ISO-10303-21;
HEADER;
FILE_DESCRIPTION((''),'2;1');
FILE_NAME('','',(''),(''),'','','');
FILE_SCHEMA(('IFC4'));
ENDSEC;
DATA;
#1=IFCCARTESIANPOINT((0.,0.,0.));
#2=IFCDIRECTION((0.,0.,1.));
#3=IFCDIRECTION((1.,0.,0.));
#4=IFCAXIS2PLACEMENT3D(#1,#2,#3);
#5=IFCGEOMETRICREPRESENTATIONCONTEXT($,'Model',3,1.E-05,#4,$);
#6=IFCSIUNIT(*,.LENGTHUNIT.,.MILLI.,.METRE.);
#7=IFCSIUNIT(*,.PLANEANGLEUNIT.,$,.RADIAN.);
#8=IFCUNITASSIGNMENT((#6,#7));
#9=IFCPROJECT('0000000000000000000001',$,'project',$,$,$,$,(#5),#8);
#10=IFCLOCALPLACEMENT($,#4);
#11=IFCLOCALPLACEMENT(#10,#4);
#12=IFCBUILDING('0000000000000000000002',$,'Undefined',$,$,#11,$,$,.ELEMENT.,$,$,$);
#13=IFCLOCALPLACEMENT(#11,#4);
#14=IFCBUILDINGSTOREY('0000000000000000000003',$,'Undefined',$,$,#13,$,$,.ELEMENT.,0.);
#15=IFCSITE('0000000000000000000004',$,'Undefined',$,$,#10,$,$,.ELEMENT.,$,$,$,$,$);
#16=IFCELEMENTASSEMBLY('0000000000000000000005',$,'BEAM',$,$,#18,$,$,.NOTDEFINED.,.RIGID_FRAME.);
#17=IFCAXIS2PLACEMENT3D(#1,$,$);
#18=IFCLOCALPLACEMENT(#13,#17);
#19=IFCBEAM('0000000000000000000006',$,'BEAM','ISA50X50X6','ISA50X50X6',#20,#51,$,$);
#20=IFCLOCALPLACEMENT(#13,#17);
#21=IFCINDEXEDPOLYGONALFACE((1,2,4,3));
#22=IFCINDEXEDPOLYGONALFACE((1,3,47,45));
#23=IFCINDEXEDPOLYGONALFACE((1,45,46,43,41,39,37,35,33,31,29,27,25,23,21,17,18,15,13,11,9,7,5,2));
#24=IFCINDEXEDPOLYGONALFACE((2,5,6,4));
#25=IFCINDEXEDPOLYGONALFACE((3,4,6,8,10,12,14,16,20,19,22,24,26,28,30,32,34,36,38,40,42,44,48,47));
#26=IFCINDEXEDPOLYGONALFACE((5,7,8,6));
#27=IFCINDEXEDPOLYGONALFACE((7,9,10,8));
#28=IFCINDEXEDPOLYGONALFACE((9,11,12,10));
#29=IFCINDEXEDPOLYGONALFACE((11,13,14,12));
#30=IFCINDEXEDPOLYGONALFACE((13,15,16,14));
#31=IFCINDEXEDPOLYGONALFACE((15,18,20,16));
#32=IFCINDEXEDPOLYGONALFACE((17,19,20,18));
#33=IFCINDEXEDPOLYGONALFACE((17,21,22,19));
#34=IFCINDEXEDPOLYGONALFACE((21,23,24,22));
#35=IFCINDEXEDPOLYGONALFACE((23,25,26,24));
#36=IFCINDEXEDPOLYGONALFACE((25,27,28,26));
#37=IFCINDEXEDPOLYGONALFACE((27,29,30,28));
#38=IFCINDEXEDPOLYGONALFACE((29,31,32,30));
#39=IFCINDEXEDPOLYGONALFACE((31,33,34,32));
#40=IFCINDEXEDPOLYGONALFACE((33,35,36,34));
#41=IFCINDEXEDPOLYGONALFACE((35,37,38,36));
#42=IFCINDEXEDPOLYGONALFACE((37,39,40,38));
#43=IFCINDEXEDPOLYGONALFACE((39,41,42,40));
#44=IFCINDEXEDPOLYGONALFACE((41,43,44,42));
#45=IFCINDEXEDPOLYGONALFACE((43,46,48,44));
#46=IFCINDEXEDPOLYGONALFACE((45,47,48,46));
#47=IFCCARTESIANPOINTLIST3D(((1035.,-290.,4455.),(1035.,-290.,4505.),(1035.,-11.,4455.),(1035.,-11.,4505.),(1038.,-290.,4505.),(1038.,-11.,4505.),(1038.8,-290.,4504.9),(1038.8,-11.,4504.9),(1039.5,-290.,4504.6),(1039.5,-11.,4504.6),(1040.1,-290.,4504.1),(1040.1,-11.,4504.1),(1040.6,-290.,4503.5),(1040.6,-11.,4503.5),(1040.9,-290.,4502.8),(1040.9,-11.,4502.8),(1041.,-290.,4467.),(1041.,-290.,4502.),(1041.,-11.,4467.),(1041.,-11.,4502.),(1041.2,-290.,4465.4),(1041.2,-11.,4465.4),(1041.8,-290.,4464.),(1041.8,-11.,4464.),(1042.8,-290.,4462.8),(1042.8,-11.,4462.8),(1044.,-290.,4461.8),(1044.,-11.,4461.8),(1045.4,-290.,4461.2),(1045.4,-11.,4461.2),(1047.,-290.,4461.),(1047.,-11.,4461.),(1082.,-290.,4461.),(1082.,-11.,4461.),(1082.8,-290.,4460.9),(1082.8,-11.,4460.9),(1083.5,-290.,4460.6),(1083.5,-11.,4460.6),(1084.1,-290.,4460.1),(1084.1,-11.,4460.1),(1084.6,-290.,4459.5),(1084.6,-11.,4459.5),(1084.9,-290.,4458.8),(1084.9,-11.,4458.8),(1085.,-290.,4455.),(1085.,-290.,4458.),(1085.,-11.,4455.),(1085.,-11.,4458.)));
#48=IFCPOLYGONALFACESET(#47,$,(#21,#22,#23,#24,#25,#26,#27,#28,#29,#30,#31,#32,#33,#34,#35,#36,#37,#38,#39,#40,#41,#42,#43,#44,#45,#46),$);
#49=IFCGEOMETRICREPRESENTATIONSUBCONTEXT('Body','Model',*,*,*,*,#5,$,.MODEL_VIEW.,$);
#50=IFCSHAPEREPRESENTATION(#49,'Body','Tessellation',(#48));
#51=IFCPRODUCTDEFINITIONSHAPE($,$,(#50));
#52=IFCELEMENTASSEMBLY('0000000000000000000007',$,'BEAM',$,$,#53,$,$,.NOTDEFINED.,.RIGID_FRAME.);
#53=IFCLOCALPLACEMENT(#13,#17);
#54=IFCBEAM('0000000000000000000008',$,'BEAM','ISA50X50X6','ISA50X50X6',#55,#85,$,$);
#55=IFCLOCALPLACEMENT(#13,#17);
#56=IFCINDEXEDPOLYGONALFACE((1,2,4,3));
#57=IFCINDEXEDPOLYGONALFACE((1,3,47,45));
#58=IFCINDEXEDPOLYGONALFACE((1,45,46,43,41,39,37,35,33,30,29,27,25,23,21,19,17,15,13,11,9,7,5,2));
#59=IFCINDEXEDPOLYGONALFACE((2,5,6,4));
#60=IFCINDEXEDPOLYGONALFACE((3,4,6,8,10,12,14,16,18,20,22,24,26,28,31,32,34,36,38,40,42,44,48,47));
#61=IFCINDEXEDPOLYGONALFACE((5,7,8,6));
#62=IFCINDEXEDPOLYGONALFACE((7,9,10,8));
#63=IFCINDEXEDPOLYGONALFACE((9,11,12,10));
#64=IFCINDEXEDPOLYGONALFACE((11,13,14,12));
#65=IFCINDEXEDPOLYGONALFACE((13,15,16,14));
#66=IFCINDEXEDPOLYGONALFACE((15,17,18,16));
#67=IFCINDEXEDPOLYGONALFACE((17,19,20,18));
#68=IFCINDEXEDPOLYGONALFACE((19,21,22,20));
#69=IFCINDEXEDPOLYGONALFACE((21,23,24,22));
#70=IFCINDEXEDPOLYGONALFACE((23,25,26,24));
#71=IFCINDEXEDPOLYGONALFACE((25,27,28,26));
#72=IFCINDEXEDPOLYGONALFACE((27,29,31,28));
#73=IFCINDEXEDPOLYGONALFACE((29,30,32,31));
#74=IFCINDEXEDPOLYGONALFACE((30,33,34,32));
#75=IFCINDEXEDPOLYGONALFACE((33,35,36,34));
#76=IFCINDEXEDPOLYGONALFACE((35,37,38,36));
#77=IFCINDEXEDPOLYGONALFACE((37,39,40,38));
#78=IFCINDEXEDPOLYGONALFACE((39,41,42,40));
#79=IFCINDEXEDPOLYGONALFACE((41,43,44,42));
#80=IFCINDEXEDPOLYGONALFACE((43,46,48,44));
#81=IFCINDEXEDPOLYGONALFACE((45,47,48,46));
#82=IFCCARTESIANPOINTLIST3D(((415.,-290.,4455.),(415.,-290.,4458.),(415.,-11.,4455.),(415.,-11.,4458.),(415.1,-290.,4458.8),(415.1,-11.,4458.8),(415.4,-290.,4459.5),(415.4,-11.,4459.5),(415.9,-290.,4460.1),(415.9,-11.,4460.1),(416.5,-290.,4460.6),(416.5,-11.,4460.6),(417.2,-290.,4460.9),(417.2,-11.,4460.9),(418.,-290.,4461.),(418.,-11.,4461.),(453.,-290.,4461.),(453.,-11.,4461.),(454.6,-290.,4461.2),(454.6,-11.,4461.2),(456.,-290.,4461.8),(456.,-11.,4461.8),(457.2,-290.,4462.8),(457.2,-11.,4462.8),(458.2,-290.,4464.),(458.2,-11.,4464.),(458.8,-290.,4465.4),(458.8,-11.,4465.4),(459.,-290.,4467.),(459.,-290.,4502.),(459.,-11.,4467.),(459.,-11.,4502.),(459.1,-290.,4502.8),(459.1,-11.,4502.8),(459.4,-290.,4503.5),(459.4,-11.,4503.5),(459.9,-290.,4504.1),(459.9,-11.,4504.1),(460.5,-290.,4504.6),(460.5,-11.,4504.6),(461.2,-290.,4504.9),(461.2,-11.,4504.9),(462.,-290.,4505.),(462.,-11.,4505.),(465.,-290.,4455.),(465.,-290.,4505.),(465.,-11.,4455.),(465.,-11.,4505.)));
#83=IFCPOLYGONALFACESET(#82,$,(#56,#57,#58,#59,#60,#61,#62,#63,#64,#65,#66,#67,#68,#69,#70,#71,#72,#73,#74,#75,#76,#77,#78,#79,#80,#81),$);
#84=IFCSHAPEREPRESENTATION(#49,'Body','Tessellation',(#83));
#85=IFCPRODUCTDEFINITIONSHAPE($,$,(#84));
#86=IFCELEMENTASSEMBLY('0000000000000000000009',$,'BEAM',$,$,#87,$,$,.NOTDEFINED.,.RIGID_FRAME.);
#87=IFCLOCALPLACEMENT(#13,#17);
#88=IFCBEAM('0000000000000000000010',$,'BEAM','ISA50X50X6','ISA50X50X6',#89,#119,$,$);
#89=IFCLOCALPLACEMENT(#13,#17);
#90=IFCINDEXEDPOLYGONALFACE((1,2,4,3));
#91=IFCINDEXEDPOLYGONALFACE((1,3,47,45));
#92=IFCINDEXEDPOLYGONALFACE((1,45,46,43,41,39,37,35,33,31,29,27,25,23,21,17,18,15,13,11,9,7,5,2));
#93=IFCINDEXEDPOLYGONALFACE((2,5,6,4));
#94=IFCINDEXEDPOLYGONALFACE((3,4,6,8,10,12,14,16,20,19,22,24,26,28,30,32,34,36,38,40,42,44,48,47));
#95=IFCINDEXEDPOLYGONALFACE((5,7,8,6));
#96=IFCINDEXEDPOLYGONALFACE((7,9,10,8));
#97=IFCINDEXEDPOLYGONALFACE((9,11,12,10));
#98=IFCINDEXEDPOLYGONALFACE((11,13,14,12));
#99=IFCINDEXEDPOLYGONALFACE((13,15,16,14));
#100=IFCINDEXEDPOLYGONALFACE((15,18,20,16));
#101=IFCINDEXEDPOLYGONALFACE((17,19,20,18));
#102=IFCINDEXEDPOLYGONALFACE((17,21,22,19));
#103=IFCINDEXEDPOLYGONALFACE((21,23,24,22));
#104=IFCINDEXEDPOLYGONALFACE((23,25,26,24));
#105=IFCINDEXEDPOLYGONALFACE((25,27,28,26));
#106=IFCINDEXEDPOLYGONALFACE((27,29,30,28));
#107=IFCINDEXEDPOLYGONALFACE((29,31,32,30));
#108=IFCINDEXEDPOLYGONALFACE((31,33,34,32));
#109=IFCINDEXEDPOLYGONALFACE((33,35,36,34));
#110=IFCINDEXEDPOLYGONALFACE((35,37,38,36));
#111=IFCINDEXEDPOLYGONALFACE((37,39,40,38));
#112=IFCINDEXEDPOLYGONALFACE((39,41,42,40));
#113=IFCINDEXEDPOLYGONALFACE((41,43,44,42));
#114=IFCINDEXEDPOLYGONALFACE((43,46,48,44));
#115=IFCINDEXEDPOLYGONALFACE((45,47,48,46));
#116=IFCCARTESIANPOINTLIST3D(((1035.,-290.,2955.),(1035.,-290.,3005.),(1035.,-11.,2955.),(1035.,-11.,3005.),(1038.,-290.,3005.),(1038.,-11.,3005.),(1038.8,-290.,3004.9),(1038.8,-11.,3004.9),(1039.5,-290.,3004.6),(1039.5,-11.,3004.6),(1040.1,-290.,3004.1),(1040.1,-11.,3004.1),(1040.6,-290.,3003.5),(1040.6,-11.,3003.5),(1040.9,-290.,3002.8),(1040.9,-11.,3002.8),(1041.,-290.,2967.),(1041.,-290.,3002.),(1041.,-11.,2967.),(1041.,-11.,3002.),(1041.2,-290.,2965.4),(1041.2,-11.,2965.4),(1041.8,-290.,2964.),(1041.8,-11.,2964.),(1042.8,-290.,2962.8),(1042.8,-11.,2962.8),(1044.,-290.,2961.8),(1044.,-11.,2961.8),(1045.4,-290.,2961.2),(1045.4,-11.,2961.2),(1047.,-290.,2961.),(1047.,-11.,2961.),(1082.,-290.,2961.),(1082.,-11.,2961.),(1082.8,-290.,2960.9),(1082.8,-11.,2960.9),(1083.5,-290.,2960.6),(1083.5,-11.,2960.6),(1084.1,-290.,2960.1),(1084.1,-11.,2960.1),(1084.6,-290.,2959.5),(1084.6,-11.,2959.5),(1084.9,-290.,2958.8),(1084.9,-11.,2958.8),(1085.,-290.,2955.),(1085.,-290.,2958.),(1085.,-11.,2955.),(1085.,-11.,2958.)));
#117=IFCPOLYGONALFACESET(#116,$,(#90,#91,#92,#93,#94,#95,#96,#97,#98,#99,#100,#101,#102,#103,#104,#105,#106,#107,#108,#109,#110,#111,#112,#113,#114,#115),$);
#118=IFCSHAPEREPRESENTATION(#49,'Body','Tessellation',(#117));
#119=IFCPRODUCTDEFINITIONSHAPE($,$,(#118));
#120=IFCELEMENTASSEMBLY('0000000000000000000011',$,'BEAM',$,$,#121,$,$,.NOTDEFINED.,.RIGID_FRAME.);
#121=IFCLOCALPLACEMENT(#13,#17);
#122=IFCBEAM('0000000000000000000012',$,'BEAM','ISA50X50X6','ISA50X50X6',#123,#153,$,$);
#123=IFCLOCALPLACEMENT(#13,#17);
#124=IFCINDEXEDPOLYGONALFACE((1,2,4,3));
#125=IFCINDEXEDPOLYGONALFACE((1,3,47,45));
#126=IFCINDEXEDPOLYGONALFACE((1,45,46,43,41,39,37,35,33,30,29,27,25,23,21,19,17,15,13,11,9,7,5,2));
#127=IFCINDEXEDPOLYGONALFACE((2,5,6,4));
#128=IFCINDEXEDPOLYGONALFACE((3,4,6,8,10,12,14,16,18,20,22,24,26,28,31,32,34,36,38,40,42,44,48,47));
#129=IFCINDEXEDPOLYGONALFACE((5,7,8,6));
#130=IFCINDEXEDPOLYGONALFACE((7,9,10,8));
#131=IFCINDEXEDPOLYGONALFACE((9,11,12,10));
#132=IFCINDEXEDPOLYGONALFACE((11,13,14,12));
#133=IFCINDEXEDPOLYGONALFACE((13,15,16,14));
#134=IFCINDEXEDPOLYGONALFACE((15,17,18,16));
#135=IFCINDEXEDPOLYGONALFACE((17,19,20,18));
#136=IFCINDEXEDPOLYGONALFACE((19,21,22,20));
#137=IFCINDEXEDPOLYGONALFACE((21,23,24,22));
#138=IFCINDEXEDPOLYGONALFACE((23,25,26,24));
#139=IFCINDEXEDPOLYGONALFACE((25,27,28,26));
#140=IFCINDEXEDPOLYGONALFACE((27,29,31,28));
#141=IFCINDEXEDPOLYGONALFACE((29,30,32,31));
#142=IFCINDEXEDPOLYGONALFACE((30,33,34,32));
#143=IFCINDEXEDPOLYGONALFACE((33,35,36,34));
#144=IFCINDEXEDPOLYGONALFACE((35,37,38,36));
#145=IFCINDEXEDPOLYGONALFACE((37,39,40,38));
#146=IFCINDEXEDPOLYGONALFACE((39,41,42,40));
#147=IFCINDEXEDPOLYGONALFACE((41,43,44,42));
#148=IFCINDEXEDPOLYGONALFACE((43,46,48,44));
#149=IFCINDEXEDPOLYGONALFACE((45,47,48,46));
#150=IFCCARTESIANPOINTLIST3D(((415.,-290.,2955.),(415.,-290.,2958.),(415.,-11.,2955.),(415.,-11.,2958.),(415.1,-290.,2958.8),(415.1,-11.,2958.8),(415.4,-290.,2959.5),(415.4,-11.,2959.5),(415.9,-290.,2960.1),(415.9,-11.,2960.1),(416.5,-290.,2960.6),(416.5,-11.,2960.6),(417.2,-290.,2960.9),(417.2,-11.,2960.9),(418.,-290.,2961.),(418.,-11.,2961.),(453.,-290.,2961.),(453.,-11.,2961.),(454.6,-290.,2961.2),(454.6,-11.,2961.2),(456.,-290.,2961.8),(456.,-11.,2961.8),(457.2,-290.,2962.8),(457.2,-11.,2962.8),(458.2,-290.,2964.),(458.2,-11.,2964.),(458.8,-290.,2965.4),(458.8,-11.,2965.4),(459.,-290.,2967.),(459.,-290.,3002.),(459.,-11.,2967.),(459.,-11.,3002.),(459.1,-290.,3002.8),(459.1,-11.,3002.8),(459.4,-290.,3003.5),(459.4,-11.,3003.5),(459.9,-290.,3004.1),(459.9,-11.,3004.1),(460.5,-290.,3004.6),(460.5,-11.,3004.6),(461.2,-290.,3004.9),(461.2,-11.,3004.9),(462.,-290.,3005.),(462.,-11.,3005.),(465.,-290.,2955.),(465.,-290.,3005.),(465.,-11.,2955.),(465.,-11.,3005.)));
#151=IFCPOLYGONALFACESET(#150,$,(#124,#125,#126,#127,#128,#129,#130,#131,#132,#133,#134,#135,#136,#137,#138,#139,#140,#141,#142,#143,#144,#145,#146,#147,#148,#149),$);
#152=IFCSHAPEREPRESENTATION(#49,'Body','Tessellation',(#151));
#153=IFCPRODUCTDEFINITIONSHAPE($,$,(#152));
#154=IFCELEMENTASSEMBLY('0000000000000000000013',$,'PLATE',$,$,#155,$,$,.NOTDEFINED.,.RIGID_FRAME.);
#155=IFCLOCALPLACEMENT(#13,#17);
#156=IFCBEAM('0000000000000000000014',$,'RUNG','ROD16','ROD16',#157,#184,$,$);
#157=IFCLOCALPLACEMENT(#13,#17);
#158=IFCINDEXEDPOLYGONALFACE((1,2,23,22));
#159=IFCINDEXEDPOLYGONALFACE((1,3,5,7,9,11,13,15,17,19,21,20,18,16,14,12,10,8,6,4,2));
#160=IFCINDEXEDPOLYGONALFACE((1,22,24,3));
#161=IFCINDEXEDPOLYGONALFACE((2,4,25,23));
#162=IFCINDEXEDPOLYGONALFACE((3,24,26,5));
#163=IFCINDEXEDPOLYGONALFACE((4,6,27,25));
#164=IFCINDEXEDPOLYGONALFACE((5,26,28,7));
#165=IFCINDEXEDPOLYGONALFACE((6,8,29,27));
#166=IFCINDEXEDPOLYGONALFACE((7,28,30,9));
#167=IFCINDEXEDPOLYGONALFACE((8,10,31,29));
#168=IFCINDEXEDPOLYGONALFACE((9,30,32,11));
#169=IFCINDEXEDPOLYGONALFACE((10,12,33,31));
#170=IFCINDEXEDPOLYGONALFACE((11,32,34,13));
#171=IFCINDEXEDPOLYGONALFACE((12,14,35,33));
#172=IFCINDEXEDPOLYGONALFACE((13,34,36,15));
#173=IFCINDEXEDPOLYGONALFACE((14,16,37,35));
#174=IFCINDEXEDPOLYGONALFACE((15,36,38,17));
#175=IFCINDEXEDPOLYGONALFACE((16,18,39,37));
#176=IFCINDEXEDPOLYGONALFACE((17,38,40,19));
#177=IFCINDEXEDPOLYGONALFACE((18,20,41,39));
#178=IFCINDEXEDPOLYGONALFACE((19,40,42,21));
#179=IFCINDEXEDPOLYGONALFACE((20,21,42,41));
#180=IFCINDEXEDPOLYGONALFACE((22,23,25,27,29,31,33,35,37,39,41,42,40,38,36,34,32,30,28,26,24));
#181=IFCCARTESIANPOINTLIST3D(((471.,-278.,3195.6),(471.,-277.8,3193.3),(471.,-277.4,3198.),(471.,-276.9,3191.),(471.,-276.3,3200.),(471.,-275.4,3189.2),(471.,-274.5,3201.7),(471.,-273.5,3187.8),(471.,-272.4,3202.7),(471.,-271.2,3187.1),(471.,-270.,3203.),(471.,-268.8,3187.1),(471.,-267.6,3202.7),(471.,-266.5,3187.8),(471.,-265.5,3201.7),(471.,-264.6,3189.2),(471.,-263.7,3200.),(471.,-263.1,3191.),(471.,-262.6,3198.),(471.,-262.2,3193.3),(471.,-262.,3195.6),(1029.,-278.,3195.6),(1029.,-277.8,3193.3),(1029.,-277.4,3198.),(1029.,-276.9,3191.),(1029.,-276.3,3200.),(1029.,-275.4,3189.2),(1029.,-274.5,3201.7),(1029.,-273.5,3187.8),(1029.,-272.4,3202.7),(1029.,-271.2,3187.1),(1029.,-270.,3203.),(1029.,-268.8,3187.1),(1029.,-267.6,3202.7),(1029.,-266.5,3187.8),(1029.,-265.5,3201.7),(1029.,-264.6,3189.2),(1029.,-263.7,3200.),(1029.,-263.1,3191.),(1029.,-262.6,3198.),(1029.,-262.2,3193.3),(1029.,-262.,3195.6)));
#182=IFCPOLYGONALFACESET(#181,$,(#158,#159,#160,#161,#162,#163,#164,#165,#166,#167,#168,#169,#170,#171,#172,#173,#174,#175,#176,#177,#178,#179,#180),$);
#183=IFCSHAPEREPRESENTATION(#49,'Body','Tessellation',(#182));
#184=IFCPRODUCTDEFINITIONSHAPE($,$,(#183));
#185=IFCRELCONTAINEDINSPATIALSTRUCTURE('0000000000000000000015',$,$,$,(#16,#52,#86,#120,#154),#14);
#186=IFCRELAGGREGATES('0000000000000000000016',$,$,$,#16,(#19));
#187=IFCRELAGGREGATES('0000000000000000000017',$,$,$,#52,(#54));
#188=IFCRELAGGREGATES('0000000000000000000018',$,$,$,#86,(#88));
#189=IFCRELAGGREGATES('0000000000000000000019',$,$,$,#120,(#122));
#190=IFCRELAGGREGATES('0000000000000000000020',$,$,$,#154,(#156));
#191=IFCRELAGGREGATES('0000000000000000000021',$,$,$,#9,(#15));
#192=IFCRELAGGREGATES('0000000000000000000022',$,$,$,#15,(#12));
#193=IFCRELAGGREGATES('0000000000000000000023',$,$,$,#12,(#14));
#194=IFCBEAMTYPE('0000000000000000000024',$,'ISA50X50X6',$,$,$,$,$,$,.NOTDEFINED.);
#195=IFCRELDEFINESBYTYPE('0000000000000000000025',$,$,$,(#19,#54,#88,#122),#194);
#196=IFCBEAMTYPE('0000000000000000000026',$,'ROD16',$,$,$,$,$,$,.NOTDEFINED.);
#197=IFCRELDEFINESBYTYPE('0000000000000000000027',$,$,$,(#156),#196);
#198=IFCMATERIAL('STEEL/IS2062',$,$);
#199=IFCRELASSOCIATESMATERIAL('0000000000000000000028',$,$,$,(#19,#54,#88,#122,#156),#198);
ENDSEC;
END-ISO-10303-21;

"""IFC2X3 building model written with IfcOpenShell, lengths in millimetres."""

from ifc_helpers import new_model, si_unit, frame, origin_with_axes, origin_2d_with_axis, place, context, subcontext, project, spatial, circle, l_section, extrude, material, type_object, element, aggregate, save


model = new_model("IFC2X3")

# Units and contexts
model_context = context("Model", 3, precision=1e-05, world=origin_with_axes())
body_context = subcontext(model_context, "Body", "Model", "MODEL_VIEW")
ifc_project = project(units=[si_unit("LENGTHUNIT", "METRE", prefix="MILLI"), si_unit("PLANEANGLEUNIT", "RADIAN")], contexts=[model_context])

# Site, building, storey
site_placement = place(None, origin_with_axes())
site = spatial("IfcSite", under=ifc_project, at=site_placement, Name="Undefined", CompositionType="ELEMENT")
building_placement = place(site_placement, origin_with_axes())
building = spatial("IfcBuilding", under=site, at=building_placement, Name="Undefined", CompositionType="ELEMENT")
storey_placement = place(building_placement, origin_with_axes())
storey = spatial("IfcBuildingStorey", under=building, at=storey_placement, Name="Undefined", CompositionType="ELEMENT", Elevation=0.0)

# Element assemblies, beams
assembly_1_placement = place(storey_placement, origin_with_axes())
assembly_1 = element("IfcElementAssembly", 1, at=assembly_1_placement, inside=storey, Name="BEAM", AssemblyPlace="NOTDEFINED", PredefinedType="RIGID_FRAME")
ifc_material = material(Name="STEEL/IS2062")
beam_type_1 = type_object("IfcBeamType", Name="ISA50X50X6", PredefinedType="NOTDEFINED")
beam_1_placement = place(assembly_1_placement, frame((1060.0, -290.0, 4480.0), z_axis=(0.0, 0.0, 1.0), x_axis=(0.0, 1.0, 0.0)))
beam_1 = element("IfcBeam", 2, at=beam_1_placement, type_object=beam_type_1, material=ifc_material, Name="BEAM", Description="ISA50X50X6", ObjectType="ISA50X50X6", context=body_context, shape_type="SweptSolid", body=[
    extrude(l_section(Depth=50.0, Width=50.0, Thickness=6.0, FilletRadius=6.0, EdgeRadius=3.0, at=origin_2d_with_axis()), frame((279.0, 0.0, 0.0), z_axis=(-1.0, 0.0, 0.0), x_axis=(0.0, -1.0, 0.0)), (0.0, 0.0, 1.0), 279.0),
])
aggregate(assembly_1, [beam_1])
assembly_2_placement = place(storey_placement, origin_with_axes())
assembly_2 = element("IfcElementAssembly", 3, at=assembly_2_placement, inside=storey, Name="BEAM", AssemblyPlace="NOTDEFINED", PredefinedType="RIGID_FRAME")
beam_2_placement = place(assembly_2_placement, frame((440.0, -11.0, 4480.0), z_axis=(0.0, 0.0, 1.0), x_axis=(0.0, -1.0, 0.0)))
beam_2 = element("IfcBeam", 4, at=beam_2_placement, type_object=beam_type_1, material=ifc_material, Name="BEAM", Description="ISA50X50X6", ObjectType="ISA50X50X6", context=body_context, shape_type="SweptSolid", body=[
    extrude(l_section(Depth=50.0, Width=50.0, Thickness=6.0, FilletRadius=6.0, EdgeRadius=3.0, at=origin_2d_with_axis()), frame((279.0, 0.0, 0.0), z_axis=(-1.0, 0.0, 0.0), x_axis=(0.0, -1.0, 0.0)), (0.0, 0.0, 1.0), 279.0),
])
aggregate(assembly_2, [beam_2])
assembly_3_placement = place(storey_placement, origin_with_axes())
assembly_3 = element("IfcElementAssembly", 5, at=assembly_3_placement, inside=storey, Name="BEAM", AssemblyPlace="NOTDEFINED", PredefinedType="RIGID_FRAME")
beam_3_placement = place(assembly_3_placement, frame((1060.0, -290.0, 2980.0), z_axis=(0.0, 0.0, 1.0), x_axis=(0.0, 1.0, 0.0)))
beam_3 = element("IfcBeam", 6, at=beam_3_placement, type_object=beam_type_1, material=ifc_material, Name="BEAM", Description="ISA50X50X6", ObjectType="ISA50X50X6", context=body_context, shape_type="SweptSolid", body=[
    extrude(l_section(Depth=50.0, Width=50.0, Thickness=6.0, FilletRadius=6.0, EdgeRadius=3.0, at=origin_2d_with_axis()), frame((279.0, 0.0, 0.0), z_axis=(-1.0, 0.0, 0.0), x_axis=(0.0, -1.0, 0.0)), (0.0, 0.0, 1.0), 279.0),
])
aggregate(assembly_3, [beam_3])
assembly_4_placement = place(storey_placement, origin_with_axes())
assembly_4 = element("IfcElementAssembly", 7, at=assembly_4_placement, inside=storey, Name="BEAM", AssemblyPlace="NOTDEFINED", PredefinedType="RIGID_FRAME")
beam_4_placement = place(assembly_4_placement, frame((440.0, -11.0, 2980.0), z_axis=(0.0, 0.0, 1.0), x_axis=(0.0, -1.0, 0.0)))
beam_4 = element("IfcBeam", 8, at=beam_4_placement, type_object=beam_type_1, material=ifc_material, Name="BEAM", Description="ISA50X50X6", ObjectType="ISA50X50X6", context=body_context, shape_type="SweptSolid", body=[
    extrude(l_section(Depth=50.0, Width=50.0, Thickness=6.0, FilletRadius=6.0, EdgeRadius=3.0, at=origin_2d_with_axis()), frame((279.0, 0.0, 0.0), z_axis=(-1.0, 0.0, 0.0), x_axis=(0.0, -1.0, 0.0)), (0.0, 0.0, 1.0), 279.0),
])
aggregate(assembly_4, [beam_4])

# Element assembly, beam
assembly_5_placement = place(storey_placement, origin_with_axes())
assembly_5 = element("IfcElementAssembly", 9, at=assembly_5_placement, inside=storey, Name="PLATE", AssemblyPlace="NOTDEFINED", PredefinedType="RIGID_FRAME")
beam_type_2 = type_object("IfcBeamType", Name="ROD16", PredefinedType="NOTDEFINED")
beam_5_placement = place(assembly_5_placement, frame((471.0, -270.0, 3195.1), z_axis=(0.0, 1.0, 0.0), x_axis=(1.0, 0.0, 0.0)))
beam_5 = element("IfcBeam", 10, at=beam_5_placement, type_object=beam_type_2, material=ifc_material, Name="RUNG", Description="ROD16", ObjectType="ROD16", context=body_context, shape_type="SweptSolid", body=[
    extrude(circle(Radius=8.0, at=origin_2d_with_axis()), frame((558.0, 0.0, 0.0), z_axis=(-1.0, 0.0, 0.0), x_axis=(0.0, -1.0, 0.0)), (0.0, 0.0, 1.0), 558.0),
])
aggregate(assembly_5, [beam_5])

save(model, "model.ifc")
